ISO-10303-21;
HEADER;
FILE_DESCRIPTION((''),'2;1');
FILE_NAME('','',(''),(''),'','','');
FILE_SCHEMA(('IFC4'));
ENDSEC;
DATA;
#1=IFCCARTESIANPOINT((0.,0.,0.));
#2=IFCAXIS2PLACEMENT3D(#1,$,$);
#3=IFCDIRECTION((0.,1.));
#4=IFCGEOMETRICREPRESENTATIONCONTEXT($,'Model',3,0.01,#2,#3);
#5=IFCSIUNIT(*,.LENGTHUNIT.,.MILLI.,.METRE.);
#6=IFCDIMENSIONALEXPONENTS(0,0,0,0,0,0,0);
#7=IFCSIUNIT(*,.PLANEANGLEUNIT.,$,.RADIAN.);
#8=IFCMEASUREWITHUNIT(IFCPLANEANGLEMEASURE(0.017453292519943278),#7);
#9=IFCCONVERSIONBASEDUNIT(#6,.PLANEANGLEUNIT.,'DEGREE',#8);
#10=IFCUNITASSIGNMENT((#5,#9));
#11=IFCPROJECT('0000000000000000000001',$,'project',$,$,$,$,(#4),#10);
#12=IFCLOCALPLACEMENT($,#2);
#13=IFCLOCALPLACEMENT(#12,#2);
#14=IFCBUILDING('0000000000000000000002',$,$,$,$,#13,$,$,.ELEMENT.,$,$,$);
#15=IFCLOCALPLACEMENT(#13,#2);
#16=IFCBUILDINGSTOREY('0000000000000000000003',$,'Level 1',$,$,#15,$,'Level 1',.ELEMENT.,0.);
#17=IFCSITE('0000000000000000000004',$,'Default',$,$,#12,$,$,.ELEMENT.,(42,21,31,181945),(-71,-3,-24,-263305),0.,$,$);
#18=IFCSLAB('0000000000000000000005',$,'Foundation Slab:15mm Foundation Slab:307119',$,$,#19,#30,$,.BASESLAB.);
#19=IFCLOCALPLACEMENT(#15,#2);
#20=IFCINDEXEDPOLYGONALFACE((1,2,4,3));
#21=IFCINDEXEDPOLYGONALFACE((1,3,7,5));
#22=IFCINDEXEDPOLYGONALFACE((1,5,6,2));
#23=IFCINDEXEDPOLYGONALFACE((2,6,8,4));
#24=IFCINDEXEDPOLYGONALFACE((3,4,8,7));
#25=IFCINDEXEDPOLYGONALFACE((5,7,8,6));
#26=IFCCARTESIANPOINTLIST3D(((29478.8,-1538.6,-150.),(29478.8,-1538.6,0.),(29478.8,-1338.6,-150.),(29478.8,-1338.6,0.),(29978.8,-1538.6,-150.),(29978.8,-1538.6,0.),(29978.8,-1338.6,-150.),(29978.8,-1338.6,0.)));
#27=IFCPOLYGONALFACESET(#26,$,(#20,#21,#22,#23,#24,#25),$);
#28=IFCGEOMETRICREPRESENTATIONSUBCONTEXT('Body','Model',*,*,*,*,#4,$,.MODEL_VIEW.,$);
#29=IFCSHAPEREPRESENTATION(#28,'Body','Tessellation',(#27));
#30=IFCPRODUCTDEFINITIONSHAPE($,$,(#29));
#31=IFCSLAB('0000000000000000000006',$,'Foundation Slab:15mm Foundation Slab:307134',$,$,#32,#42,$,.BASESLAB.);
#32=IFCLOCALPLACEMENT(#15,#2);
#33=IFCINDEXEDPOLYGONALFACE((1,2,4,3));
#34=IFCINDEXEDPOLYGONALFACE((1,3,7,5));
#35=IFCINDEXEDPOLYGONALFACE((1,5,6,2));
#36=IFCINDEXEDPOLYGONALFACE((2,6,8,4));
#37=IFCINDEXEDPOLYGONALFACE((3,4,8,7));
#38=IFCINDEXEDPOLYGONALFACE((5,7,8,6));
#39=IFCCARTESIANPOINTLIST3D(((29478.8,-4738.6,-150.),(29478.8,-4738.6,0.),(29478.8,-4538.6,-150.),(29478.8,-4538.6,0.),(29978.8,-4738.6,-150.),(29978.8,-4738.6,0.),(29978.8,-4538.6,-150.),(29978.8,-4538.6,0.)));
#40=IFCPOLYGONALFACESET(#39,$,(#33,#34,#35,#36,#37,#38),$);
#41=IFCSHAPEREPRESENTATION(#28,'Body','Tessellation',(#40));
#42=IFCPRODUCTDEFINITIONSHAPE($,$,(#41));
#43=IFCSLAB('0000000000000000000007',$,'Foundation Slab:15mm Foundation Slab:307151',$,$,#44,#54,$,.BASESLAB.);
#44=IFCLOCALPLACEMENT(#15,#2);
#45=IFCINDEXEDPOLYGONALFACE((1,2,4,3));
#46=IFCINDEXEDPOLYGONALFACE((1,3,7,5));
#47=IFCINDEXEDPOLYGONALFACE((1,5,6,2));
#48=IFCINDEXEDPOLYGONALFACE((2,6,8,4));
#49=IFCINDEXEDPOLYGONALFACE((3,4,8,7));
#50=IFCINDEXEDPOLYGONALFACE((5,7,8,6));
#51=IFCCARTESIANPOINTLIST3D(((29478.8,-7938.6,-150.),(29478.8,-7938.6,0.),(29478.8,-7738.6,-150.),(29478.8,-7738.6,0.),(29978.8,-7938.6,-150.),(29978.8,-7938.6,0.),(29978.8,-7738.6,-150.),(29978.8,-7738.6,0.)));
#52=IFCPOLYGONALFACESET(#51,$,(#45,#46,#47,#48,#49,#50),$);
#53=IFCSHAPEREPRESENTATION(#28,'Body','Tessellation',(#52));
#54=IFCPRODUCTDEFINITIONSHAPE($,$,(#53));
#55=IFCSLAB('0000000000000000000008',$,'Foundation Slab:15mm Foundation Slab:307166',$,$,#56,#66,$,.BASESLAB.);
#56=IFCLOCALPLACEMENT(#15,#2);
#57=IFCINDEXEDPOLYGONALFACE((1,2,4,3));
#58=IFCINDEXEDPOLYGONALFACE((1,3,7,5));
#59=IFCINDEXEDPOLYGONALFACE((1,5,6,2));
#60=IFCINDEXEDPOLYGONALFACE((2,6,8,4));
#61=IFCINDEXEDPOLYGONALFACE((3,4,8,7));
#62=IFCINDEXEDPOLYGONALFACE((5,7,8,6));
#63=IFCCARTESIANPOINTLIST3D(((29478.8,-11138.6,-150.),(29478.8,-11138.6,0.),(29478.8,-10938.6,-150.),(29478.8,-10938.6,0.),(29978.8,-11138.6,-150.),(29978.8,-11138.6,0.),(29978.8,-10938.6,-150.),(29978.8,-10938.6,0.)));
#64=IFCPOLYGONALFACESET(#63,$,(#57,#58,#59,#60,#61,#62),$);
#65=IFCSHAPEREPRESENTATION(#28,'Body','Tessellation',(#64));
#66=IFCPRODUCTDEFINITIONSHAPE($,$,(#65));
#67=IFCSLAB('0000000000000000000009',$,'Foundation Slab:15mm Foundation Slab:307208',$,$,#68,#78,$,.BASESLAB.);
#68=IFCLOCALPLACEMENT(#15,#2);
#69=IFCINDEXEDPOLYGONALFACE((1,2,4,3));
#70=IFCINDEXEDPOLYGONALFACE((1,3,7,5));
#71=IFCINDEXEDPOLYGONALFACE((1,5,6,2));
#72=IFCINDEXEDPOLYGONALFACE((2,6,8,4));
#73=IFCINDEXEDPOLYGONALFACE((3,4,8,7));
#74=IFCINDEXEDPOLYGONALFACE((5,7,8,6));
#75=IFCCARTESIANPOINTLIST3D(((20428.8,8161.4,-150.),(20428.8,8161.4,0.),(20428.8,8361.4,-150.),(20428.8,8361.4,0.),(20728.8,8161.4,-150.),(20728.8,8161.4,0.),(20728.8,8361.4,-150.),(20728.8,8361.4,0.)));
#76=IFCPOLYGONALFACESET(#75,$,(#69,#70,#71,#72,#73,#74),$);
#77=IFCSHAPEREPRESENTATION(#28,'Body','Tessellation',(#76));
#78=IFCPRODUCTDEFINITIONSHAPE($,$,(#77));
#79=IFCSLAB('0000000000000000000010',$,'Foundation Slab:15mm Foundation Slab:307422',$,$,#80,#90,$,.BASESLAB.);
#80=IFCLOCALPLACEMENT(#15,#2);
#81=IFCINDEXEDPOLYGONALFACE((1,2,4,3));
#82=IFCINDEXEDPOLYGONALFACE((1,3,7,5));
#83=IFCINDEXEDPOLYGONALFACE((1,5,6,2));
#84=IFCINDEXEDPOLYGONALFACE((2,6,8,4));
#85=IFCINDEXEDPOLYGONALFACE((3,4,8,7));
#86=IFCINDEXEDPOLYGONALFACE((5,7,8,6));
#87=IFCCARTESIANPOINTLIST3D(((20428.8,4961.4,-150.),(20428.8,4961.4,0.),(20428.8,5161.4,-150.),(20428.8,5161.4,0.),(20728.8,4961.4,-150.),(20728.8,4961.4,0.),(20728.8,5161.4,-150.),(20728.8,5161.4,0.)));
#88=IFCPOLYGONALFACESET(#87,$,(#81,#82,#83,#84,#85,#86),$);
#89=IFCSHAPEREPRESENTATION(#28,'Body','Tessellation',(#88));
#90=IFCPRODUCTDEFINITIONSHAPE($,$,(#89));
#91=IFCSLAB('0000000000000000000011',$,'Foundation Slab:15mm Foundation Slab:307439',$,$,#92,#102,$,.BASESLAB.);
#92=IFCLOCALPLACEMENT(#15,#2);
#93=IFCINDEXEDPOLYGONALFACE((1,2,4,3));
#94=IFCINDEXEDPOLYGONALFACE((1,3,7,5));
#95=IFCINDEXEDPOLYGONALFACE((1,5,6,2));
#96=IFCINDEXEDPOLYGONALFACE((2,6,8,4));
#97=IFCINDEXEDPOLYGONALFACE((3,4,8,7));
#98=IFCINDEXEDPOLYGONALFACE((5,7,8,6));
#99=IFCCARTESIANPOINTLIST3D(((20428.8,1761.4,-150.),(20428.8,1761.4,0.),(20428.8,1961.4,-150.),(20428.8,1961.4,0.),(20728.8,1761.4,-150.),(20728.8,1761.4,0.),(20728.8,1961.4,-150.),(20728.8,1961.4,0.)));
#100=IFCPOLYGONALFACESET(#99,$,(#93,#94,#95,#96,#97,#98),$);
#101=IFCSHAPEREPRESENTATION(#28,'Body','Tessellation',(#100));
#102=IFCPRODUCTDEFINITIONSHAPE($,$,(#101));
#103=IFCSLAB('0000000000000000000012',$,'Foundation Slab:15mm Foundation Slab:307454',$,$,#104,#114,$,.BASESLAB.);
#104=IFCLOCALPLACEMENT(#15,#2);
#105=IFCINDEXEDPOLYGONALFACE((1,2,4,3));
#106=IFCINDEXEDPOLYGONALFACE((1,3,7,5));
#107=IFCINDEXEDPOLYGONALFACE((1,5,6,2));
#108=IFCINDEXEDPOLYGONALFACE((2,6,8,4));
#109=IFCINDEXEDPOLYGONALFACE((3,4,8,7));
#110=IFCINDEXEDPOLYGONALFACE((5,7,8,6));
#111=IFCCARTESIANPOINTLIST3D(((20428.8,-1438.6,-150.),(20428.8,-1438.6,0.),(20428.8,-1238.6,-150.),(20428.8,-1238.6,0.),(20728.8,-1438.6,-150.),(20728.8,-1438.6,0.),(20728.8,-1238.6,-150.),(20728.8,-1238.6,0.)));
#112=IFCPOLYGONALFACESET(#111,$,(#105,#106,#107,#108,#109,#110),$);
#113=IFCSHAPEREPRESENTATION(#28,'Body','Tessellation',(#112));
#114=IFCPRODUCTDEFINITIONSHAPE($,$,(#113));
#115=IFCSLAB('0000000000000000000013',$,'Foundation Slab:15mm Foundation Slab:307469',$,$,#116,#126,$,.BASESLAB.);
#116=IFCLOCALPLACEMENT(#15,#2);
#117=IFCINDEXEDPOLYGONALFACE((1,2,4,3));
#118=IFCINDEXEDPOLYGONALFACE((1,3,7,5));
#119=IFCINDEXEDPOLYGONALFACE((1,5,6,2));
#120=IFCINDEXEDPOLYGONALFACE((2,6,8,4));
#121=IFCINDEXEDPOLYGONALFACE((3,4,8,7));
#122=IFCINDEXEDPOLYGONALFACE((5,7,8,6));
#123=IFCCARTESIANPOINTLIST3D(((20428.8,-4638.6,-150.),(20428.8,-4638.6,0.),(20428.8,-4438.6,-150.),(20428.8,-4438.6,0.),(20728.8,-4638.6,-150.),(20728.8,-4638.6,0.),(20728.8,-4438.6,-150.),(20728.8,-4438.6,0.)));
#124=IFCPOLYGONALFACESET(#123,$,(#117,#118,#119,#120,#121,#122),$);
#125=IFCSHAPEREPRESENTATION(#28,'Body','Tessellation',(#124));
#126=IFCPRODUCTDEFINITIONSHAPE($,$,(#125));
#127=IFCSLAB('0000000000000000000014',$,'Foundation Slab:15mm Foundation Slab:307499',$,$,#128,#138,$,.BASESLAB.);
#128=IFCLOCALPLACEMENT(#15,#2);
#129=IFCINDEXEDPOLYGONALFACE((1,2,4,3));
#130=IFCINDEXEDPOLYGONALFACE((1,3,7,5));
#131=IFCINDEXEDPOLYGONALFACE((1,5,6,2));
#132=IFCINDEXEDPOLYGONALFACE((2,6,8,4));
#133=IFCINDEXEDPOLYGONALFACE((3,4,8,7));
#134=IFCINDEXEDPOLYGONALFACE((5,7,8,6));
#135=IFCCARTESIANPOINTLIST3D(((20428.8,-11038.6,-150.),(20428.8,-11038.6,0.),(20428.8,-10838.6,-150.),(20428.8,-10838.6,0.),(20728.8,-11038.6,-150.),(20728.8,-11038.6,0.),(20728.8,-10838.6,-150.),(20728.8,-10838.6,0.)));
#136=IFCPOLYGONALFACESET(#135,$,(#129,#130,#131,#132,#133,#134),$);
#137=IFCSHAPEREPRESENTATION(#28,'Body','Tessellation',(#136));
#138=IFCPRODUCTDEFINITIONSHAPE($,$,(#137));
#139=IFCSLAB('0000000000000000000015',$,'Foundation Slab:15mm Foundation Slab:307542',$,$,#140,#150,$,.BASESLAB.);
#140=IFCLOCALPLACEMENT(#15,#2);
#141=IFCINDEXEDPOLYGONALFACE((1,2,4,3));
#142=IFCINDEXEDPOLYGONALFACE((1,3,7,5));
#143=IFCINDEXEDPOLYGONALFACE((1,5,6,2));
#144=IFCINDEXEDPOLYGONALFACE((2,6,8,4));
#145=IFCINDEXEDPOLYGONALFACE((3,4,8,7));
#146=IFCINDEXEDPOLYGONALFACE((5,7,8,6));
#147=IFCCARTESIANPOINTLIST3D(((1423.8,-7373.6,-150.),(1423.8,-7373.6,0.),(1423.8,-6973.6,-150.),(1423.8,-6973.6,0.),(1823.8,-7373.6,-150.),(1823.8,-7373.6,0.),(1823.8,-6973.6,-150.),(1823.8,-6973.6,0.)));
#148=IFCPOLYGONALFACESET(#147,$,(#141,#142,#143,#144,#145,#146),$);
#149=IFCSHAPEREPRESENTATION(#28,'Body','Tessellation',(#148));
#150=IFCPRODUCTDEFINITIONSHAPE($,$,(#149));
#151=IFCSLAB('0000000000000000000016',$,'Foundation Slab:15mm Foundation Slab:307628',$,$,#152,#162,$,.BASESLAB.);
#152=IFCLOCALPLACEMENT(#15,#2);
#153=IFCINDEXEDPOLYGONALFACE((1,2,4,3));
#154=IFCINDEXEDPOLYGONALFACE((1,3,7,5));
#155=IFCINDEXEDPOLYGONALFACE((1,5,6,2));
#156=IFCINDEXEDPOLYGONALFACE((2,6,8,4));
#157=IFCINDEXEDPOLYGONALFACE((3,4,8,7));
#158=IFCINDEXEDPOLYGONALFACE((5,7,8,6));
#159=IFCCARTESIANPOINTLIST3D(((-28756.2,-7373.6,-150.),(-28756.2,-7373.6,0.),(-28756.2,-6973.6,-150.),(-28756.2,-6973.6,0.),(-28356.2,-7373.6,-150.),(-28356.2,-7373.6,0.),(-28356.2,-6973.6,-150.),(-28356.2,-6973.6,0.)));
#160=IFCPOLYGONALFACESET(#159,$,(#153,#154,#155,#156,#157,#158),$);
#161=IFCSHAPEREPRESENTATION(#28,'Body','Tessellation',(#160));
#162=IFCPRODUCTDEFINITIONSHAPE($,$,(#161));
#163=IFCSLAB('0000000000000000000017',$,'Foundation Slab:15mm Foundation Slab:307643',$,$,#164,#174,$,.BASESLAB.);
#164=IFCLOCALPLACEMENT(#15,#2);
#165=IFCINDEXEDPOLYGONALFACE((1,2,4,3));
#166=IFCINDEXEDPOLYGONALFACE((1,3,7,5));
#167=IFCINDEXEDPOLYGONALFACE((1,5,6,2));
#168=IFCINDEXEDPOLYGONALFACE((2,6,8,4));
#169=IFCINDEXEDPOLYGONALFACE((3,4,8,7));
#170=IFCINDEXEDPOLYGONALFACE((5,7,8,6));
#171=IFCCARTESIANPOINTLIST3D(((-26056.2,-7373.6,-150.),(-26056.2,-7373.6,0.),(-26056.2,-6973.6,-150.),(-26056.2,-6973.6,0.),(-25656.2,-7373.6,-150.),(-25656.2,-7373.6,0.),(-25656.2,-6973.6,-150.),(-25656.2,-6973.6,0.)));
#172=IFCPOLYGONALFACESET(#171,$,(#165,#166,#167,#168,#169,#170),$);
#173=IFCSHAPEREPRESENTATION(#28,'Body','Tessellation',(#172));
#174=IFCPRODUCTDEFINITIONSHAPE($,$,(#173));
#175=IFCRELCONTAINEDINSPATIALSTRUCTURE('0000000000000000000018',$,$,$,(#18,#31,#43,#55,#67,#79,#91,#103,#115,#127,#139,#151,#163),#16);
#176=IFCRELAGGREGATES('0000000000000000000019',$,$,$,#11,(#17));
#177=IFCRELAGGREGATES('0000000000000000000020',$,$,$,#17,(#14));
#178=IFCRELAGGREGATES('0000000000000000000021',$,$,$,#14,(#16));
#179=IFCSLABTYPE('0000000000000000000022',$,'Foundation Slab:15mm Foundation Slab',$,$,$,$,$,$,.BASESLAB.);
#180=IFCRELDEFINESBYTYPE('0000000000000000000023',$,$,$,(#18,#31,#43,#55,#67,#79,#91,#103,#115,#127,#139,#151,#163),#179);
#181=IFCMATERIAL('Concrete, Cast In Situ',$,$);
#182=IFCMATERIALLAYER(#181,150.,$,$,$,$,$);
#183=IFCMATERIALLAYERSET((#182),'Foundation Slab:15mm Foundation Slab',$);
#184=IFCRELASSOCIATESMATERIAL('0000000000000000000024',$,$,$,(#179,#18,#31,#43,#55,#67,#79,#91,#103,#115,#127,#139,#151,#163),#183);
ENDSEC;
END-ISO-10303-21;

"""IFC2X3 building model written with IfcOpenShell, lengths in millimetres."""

from ifc_helpers import new_model, entity, si_unit, converted_unit, direction, frame, frame_2d, origin, origin_2d_with_axis, place, context, subcontext, project, spatial, rectangle, extrude, material, layer, layer_set, layer_usage, type_object, element, save


model = new_model("IFC2X3")

# Units and contexts
model_context = context("Model", 3, precision=0.01, world=origin(), true_north=direction((0.0, 1.0)))
body_context = subcontext(model_context, "Body", "Model", "MODEL_VIEW")
ifc_project = project(units=[si_unit("LENGTHUNIT", "METRE", prefix="MILLI"), converted_unit("PLANEANGLEUNIT", "DEGREE", entity("IfcPlaneAngleMeasure", 0.017453292519943278), si_unit("PLANEANGLEUNIT", "RADIAN"), dimensions=[0, 0, 0, 0, 0, 0, 0])], contexts=[model_context])

# Site, building, storey
site_placement = place(None, origin())
site = spatial("IfcSite", under=ifc_project, at=site_placement, Name="Default", CompositionType="ELEMENT", RefLatitude=(42, 21, 31, 181945), RefLongitude=(-71, -3, -24, -263305), RefElevation=0.0)
building_placement = place(site_placement, origin())
building = spatial("IfcBuilding", under=site, at=building_placement, CompositionType="ELEMENT")
storey_placement = place(building_placement, origin())
storey = spatial("IfcBuildingStorey", under=building, at=storey_placement, Name="Level 1", LongName="Level 1", CompositionType="ELEMENT", Elevation=0.0)

# Slabs
ifc_material = material(Name="Concrete, Cast In Situ")
ifc_layer = layer(ifc_material, 150.0)
ifc_layer_set = layer_set([ifc_layer], Name="Foundation Slab:15mm Foundation Slab")
ifc_layer_usage_1 = layer_usage(ifc_layer_set, "AXIS3", "POSITIVE", 0.0)
slab_type = type_object("IfcSlabType", Name="Foundation Slab:15mm Foundation Slab", PredefinedType="BASESLAB", material=ifc_layer_set)
slab_1_placement = place(storey_placement, origin())
element("IfcSlab", 1, at=slab_1_placement, inside=storey, type_object=slab_type, material=ifc_layer_usage_1, Name="Foundation Slab:15mm Foundation Slab:307119", PredefinedType="BASESLAB", context=body_context, shape_type="SweptSolid", body=[
    extrude(rectangle(XDim=200.0, YDim=500.0, at=origin_2d_with_axis()), frame((29728.8, -1438.6, 0.0), z_axis=(0.0, 0.0, -1.0), x_axis=(0.0, 1.0, 0.0)), (0.0, 0.0, 1.0), 150.0),
])
ifc_layer_usage_2 = layer_usage(ifc_layer_set, "AXIS3", "POSITIVE", 0.0)
slab_2_placement = place(storey_placement, origin())
element("IfcSlab", 2, at=slab_2_placement, inside=storey, type_object=slab_type, material=ifc_layer_usage_2, Name="Foundation Slab:15mm Foundation Slab:307134", PredefinedType="BASESLAB", context=body_context, shape_type="SweptSolid", body=[
    extrude(rectangle(XDim=200.0, YDim=500.0, at=origin_2d_with_axis()), frame((29728.8, -4638.6, 0.0), z_axis=(0.0, 0.0, -1.0), x_axis=(0.0, 1.0, 0.0)), (0.0, 0.0, 1.0), 150.0),
])
ifc_layer_usage_3 = layer_usage(ifc_layer_set, "AXIS3", "POSITIVE", 0.0)
slab_3_placement = place(storey_placement, origin())
element("IfcSlab", 3, at=slab_3_placement, inside=storey, type_object=slab_type, material=ifc_layer_usage_3, Name="Foundation Slab:15mm Foundation Slab:307151", PredefinedType="BASESLAB", context=body_context, shape_type="SweptSolid", body=[
    extrude(rectangle(XDim=200.0, YDim=500.0, at=origin_2d_with_axis()), frame((29728.8, -7838.6, 0.0), z_axis=(0.0, 0.0, -1.0), x_axis=(0.0, 1.0, 0.0)), (0.0, 0.0, 1.0), 150.0),
])
ifc_layer_usage_4 = layer_usage(ifc_layer_set, "AXIS3", "POSITIVE", 0.0)
slab_4_placement = place(storey_placement, origin())
element("IfcSlab", 4, at=slab_4_placement, inside=storey, type_object=slab_type, material=ifc_layer_usage_4, Name="Foundation Slab:15mm Foundation Slab:307166", PredefinedType="BASESLAB", context=body_context, shape_type="SweptSolid", body=[
    extrude(rectangle(XDim=200.0, YDim=500.0, at=frame_2d((0.0, 0.0), x_axis=(1.0, 0.0))), frame((29728.8, -11038.6, 0.0), z_axis=(0.0, 0.0, -1.0), x_axis=(0.0, 1.0, 0.0)), (0.0, 0.0, 1.0), 150.0),
])
ifc_layer_usage_5 = layer_usage(ifc_layer_set, "AXIS3", "POSITIVE", 0.0)
slab_5_placement = place(storey_placement, origin())
element("IfcSlab", 5, at=slab_5_placement, inside=storey, type_object=slab_type, material=ifc_layer_usage_5, Name="Foundation Slab:15mm Foundation Slab:307208", PredefinedType="BASESLAB", context=body_context, shape_type="SweptSolid", body=[
    extrude(rectangle(XDim=200.0, YDim=300.0, at=origin_2d_with_axis()), frame((20578.8, 8261.4, 0.0), z_axis=(0.0, 0.0, -1.0), x_axis=(0.0, 1.0, 0.0)), (0.0, 0.0, 1.0), 150.0),
])
ifc_layer_usage_6 = layer_usage(ifc_layer_set, "AXIS3", "POSITIVE", 0.0)
slab_6_placement = place(storey_placement, origin())
element("IfcSlab", 6, at=slab_6_placement, inside=storey, type_object=slab_type, material=ifc_layer_usage_6, Name="Foundation Slab:15mm Foundation Slab:307422", PredefinedType="BASESLAB", context=body_context, shape_type="SweptSolid", body=[
    extrude(rectangle(XDim=200.0, YDim=300.0, at=origin_2d_with_axis()), frame((20578.8, 5061.4, 0.0), z_axis=(0.0, 0.0, -1.0), x_axis=(0.0, 1.0, 0.0)), (0.0, 0.0, 1.0), 150.0),
])
ifc_layer_usage_7 = layer_usage(ifc_layer_set, "AXIS3", "POSITIVE", 0.0)
slab_7_placement = place(storey_placement, origin())
element("IfcSlab", 7, at=slab_7_placement, inside=storey, type_object=slab_type, material=ifc_layer_usage_7, Name="Foundation Slab:15mm Foundation Slab:307439", PredefinedType="BASESLAB", context=body_context, shape_type="SweptSolid", body=[
    extrude(rectangle(XDim=200.0, YDim=300.0, at=origin_2d_with_axis()), frame((20578.8, 1861.4, 0.0), z_axis=(0.0, 0.0, -1.0), x_axis=(0.0, 1.0, 0.0)), (0.0, 0.0, 1.0), 150.0),
])
ifc_layer_usage_8 = layer_usage(ifc_layer_set, "AXIS3", "POSITIVE", 0.0)
slab_8_placement = place(storey_placement, origin())
element("IfcSlab", 8, at=slab_8_placement, inside=storey, type_object=slab_type, material=ifc_layer_usage_8, Name="Foundation Slab:15mm Foundation Slab:307454", PredefinedType="BASESLAB", context=body_context, shape_type="SweptSolid", body=[
    extrude(rectangle(XDim=200.0, YDim=300.0, at=origin_2d_with_axis()), frame((20578.8, -1338.6, 0.0), z_axis=(0.0, 0.0, -1.0), x_axis=(0.0, 1.0, 0.0)), (0.0, 0.0, 1.0), 150.0),
])
ifc_layer_usage_9 = layer_usage(ifc_layer_set, "AXIS3", "POSITIVE", 0.0)
slab_9_placement = place(storey_placement, origin())
element("IfcSlab", 9, at=slab_9_placement, inside=storey, type_object=slab_type, material=ifc_layer_usage_9, Name="Foundation Slab:15mm Foundation Slab:307469", PredefinedType="BASESLAB", context=body_context, shape_type="SweptSolid", body=[
    extrude(rectangle(XDim=200.0, YDim=300.0, at=origin_2d_with_axis()), frame((20578.8, -4538.6, 0.0), z_axis=(0.0, 0.0, -1.0), x_axis=(0.0, 1.0, 0.0)), (0.0, 0.0, 1.0), 150.0),
])
ifc_layer_usage_10 = layer_usage(ifc_layer_set, "AXIS3", "POSITIVE", 0.0)
slab_10_placement = place(storey_placement, origin())
element("IfcSlab", 10, at=slab_10_placement, inside=storey, type_object=slab_type, material=ifc_layer_usage_10, Name="Foundation Slab:15mm Foundation Slab:307499", PredefinedType="BASESLAB", context=body_context, shape_type="SweptSolid", body=[
    extrude(rectangle(XDim=200.0, YDim=300.0, at=frame_2d((0.0, 0.0), x_axis=(1.0, 0.0))), frame((20578.8, -10938.6, 0.0), z_axis=(0.0, 0.0, -1.0), x_axis=(0.0, 1.0, 0.0)), (0.0, 0.0, 1.0), 150.0),
])
ifc_layer_usage_11 = layer_usage(ifc_layer_set, "AXIS3", "POSITIVE", 0.0)
slab_11_placement = place(storey_placement, origin())
element("IfcSlab", 11, at=slab_11_placement, inside=storey, type_object=slab_type, material=ifc_layer_usage_11, Name="Foundation Slab:15mm Foundation Slab:307542", PredefinedType="BASESLAB", context=body_context, shape_type="SweptSolid", body=[
    extrude(rectangle(XDim=400.0, YDim=400.0, at=origin_2d_with_axis()), frame((1623.8, -7173.6, 0.0), z_axis=(0.0, 0.0, -1.0), x_axis=(0.0, 1.0, 0.0)), (0.0, 0.0, 1.0), 150.0),
])
ifc_layer_usage_12 = layer_usage(ifc_layer_set, "AXIS3", "POSITIVE", 0.0)
slab_12_placement = place(storey_placement, origin())
element("IfcSlab", 12, at=slab_12_placement, inside=storey, type_object=slab_type, material=ifc_layer_usage_12, Name="Foundation Slab:15mm Foundation Slab:307628", PredefinedType="BASESLAB", context=body_context, shape_type="SweptSolid", body=[
    extrude(rectangle(XDim=400.0, YDim=400.0, at=origin_2d_with_axis()), frame((-28556.2, -7173.6, 0.0), z_axis=(0.0, 0.0, -1.0), x_axis=(0.0, 1.0, 0.0)), (0.0, 0.0, 1.0), 150.0),
])
ifc_layer_usage_13 = layer_usage(ifc_layer_set, "AXIS3", "POSITIVE", 0.0)
slab_13_placement = place(storey_placement, origin())
element("IfcSlab", 13, at=slab_13_placement, inside=storey, type_object=slab_type, material=ifc_layer_usage_13, Name="Foundation Slab:15mm Foundation Slab:307643", PredefinedType="BASESLAB", context=body_context, shape_type="SweptSolid", body=[
    extrude(rectangle(XDim=400.0, YDim=400.0, at=origin_2d_with_axis()), frame((-25856.2, -7173.6, 0.0), z_axis=(0.0, 0.0, -1.0), x_axis=(0.0, 1.0, 0.0)), (0.0, 0.0, 1.0), 150.0),
])

save(model, "model.ifc")
